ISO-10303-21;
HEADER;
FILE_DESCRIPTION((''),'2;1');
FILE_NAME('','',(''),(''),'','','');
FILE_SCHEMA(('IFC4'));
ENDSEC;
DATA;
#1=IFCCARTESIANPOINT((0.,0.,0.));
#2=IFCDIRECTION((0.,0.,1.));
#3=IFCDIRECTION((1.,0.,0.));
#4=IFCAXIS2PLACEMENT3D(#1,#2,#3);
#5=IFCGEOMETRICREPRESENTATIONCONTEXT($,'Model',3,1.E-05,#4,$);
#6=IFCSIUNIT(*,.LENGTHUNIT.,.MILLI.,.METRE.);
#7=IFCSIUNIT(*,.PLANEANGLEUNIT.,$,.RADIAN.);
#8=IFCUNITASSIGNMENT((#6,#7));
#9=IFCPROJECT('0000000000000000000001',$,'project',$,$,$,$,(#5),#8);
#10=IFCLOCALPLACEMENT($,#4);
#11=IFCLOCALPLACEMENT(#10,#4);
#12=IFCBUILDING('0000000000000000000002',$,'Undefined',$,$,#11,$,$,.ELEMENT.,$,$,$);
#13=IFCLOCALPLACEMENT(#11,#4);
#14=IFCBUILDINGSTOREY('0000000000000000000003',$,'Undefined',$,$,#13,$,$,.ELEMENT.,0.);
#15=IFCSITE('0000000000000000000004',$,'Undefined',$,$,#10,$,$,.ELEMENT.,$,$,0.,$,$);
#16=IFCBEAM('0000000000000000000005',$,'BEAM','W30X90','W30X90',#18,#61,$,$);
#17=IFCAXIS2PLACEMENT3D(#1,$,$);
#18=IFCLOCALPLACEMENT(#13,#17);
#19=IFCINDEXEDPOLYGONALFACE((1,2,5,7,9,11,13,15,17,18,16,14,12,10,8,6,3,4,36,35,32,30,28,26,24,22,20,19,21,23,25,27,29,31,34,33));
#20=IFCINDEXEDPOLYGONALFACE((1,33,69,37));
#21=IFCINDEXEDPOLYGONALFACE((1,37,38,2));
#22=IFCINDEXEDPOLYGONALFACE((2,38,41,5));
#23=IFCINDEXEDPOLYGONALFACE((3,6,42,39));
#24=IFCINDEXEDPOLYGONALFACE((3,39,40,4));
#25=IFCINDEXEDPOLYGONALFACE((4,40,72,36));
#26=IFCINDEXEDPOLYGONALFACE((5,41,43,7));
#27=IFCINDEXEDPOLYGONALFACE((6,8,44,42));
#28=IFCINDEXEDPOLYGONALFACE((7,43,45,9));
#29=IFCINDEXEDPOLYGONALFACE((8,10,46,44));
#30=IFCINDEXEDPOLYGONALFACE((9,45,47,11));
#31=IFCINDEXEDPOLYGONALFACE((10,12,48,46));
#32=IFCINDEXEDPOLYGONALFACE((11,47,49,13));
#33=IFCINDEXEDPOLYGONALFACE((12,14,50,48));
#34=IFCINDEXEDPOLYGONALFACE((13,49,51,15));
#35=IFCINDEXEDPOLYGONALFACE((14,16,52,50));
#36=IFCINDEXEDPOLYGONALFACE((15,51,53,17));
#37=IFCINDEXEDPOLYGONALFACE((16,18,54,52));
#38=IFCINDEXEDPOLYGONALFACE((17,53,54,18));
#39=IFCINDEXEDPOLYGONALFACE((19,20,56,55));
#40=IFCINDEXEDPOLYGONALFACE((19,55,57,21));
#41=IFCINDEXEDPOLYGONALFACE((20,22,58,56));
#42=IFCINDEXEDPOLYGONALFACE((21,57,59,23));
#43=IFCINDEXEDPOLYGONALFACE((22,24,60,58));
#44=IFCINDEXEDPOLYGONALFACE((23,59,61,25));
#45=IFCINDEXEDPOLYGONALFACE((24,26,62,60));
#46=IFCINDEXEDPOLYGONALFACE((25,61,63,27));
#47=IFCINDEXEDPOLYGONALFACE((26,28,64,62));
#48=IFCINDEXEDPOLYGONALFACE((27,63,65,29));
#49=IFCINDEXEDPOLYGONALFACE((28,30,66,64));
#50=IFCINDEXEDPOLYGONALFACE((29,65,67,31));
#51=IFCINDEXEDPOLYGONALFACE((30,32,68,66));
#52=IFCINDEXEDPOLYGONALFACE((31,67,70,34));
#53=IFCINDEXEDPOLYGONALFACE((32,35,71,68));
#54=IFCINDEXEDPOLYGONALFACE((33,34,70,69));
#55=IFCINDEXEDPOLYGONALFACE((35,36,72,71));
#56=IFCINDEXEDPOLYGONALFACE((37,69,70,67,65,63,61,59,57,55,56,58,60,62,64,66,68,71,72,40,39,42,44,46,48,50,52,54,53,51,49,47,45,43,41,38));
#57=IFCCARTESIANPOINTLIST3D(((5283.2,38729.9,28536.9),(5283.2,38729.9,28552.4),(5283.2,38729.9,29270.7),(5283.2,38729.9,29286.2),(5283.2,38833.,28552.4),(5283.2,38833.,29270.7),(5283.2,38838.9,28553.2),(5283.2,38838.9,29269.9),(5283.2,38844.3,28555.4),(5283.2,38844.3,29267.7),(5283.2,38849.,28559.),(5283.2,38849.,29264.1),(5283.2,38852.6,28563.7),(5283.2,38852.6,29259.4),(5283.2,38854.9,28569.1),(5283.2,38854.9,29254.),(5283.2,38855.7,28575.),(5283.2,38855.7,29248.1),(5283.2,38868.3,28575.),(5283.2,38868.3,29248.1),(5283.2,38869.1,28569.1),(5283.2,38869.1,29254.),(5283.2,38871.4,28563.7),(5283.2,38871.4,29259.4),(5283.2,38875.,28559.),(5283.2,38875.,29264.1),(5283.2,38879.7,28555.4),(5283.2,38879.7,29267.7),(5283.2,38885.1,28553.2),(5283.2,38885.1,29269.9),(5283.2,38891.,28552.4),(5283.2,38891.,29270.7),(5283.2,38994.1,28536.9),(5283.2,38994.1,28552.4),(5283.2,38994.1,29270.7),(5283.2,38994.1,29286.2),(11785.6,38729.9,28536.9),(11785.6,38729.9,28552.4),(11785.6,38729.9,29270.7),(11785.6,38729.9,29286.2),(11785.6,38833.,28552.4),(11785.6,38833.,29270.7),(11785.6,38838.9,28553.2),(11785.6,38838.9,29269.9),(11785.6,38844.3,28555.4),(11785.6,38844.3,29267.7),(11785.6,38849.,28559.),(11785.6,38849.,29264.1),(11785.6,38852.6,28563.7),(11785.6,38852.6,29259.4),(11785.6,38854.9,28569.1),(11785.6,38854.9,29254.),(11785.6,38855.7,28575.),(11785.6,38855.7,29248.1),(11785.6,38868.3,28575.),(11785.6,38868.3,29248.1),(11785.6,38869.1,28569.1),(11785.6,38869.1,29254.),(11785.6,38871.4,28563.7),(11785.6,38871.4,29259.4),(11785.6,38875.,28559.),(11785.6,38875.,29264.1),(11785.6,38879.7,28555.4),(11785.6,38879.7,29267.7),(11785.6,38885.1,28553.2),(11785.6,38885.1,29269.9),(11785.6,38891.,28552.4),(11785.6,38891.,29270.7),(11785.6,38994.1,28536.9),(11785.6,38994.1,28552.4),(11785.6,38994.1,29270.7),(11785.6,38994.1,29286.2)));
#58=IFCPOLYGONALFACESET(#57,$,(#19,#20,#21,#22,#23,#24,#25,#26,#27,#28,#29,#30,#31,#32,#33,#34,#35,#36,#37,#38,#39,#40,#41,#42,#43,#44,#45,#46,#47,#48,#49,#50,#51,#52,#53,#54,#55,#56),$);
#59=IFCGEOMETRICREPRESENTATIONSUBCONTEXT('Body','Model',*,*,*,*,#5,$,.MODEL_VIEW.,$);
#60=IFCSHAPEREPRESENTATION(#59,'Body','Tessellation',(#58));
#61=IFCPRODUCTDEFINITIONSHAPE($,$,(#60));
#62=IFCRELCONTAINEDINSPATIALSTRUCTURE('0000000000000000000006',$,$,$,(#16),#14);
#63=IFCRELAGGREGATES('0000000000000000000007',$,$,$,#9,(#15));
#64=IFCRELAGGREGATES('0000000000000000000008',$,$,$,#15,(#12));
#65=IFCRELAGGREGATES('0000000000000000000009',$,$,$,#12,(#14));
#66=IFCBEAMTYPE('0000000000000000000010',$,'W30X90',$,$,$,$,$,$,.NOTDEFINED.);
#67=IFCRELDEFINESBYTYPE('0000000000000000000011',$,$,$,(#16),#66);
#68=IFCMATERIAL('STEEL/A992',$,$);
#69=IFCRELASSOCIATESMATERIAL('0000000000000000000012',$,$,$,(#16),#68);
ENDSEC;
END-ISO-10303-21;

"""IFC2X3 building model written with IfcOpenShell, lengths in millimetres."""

from ifc_helpers import new_model, si_unit, frame, origin_with_axes, origin_2d_with_axis, place, context, subcontext, project, spatial, i_section, extrude, material, type_object, element, save


model = new_model("IFC2X3")

# Units and contexts
model_context = context("Model", 3, precision=1e-05, world=origin_with_axes())
body_context = subcontext(model_context, "Body", "Model", "MODEL_VIEW")
ifc_project = project(units=[si_unit("LENGTHUNIT", "METRE", prefix="MILLI"), si_unit("PLANEANGLEUNIT", "RADIAN")], contexts=[model_context])

# Site, building, storey
site_placement = place(None, origin_with_axes())
site = spatial("IfcSite", under=ifc_project, at=site_placement, Name="Undefined", CompositionType="ELEMENT", RefElevation=0.0)
building_placement = place(site_placement, origin_with_axes())
building = spatial("IfcBuilding", under=site, at=building_placement, Name="Undefined", CompositionType="ELEMENT")
storey_placement = place(building_placement, origin_with_axes())
storey = spatial("IfcBuildingStorey", under=building, at=storey_placement, Name="Undefined", CompositionType="ELEMENT", Elevation=0.0)

# Shared definitions
ifc_material_1 = material(Name="STEEL/A992")

# Beam
beam_type_1 = type_object("IfcBeamType", Name="W30X90", PredefinedType="NOTDEFINED")
beam_1_placement = place(storey_placement, frame((5283.2, 38862.0, 28911.5), z_axis=(0.0, 0.0, 1.0), x_axis=(1.0, 0.0, 0.0)))
element("IfcBeam", 1, at=beam_1_placement, inside=storey, type_object=beam_type_1, material=ifc_material_1, Name="BEAM", Description="W30X90", ObjectType="W30X90", context=body_context, shape_type="SweptSolid", body=[
    extrude(i_section(OverallWidth=264.2, OverallDepth=749.3, WebThickness=12.7, FlangeThickness=15.5, FilletRadius=22.6, at=origin_2d_with_axis()), frame((6502.4, 0.0, 0.0), z_axis=(-1.0, 0.0, 0.0), x_axis=(0.0, -1.0, 0.0)), (0.0, 0.0, 1.0), 6502.4),
])

save(model, "model.ifc")
